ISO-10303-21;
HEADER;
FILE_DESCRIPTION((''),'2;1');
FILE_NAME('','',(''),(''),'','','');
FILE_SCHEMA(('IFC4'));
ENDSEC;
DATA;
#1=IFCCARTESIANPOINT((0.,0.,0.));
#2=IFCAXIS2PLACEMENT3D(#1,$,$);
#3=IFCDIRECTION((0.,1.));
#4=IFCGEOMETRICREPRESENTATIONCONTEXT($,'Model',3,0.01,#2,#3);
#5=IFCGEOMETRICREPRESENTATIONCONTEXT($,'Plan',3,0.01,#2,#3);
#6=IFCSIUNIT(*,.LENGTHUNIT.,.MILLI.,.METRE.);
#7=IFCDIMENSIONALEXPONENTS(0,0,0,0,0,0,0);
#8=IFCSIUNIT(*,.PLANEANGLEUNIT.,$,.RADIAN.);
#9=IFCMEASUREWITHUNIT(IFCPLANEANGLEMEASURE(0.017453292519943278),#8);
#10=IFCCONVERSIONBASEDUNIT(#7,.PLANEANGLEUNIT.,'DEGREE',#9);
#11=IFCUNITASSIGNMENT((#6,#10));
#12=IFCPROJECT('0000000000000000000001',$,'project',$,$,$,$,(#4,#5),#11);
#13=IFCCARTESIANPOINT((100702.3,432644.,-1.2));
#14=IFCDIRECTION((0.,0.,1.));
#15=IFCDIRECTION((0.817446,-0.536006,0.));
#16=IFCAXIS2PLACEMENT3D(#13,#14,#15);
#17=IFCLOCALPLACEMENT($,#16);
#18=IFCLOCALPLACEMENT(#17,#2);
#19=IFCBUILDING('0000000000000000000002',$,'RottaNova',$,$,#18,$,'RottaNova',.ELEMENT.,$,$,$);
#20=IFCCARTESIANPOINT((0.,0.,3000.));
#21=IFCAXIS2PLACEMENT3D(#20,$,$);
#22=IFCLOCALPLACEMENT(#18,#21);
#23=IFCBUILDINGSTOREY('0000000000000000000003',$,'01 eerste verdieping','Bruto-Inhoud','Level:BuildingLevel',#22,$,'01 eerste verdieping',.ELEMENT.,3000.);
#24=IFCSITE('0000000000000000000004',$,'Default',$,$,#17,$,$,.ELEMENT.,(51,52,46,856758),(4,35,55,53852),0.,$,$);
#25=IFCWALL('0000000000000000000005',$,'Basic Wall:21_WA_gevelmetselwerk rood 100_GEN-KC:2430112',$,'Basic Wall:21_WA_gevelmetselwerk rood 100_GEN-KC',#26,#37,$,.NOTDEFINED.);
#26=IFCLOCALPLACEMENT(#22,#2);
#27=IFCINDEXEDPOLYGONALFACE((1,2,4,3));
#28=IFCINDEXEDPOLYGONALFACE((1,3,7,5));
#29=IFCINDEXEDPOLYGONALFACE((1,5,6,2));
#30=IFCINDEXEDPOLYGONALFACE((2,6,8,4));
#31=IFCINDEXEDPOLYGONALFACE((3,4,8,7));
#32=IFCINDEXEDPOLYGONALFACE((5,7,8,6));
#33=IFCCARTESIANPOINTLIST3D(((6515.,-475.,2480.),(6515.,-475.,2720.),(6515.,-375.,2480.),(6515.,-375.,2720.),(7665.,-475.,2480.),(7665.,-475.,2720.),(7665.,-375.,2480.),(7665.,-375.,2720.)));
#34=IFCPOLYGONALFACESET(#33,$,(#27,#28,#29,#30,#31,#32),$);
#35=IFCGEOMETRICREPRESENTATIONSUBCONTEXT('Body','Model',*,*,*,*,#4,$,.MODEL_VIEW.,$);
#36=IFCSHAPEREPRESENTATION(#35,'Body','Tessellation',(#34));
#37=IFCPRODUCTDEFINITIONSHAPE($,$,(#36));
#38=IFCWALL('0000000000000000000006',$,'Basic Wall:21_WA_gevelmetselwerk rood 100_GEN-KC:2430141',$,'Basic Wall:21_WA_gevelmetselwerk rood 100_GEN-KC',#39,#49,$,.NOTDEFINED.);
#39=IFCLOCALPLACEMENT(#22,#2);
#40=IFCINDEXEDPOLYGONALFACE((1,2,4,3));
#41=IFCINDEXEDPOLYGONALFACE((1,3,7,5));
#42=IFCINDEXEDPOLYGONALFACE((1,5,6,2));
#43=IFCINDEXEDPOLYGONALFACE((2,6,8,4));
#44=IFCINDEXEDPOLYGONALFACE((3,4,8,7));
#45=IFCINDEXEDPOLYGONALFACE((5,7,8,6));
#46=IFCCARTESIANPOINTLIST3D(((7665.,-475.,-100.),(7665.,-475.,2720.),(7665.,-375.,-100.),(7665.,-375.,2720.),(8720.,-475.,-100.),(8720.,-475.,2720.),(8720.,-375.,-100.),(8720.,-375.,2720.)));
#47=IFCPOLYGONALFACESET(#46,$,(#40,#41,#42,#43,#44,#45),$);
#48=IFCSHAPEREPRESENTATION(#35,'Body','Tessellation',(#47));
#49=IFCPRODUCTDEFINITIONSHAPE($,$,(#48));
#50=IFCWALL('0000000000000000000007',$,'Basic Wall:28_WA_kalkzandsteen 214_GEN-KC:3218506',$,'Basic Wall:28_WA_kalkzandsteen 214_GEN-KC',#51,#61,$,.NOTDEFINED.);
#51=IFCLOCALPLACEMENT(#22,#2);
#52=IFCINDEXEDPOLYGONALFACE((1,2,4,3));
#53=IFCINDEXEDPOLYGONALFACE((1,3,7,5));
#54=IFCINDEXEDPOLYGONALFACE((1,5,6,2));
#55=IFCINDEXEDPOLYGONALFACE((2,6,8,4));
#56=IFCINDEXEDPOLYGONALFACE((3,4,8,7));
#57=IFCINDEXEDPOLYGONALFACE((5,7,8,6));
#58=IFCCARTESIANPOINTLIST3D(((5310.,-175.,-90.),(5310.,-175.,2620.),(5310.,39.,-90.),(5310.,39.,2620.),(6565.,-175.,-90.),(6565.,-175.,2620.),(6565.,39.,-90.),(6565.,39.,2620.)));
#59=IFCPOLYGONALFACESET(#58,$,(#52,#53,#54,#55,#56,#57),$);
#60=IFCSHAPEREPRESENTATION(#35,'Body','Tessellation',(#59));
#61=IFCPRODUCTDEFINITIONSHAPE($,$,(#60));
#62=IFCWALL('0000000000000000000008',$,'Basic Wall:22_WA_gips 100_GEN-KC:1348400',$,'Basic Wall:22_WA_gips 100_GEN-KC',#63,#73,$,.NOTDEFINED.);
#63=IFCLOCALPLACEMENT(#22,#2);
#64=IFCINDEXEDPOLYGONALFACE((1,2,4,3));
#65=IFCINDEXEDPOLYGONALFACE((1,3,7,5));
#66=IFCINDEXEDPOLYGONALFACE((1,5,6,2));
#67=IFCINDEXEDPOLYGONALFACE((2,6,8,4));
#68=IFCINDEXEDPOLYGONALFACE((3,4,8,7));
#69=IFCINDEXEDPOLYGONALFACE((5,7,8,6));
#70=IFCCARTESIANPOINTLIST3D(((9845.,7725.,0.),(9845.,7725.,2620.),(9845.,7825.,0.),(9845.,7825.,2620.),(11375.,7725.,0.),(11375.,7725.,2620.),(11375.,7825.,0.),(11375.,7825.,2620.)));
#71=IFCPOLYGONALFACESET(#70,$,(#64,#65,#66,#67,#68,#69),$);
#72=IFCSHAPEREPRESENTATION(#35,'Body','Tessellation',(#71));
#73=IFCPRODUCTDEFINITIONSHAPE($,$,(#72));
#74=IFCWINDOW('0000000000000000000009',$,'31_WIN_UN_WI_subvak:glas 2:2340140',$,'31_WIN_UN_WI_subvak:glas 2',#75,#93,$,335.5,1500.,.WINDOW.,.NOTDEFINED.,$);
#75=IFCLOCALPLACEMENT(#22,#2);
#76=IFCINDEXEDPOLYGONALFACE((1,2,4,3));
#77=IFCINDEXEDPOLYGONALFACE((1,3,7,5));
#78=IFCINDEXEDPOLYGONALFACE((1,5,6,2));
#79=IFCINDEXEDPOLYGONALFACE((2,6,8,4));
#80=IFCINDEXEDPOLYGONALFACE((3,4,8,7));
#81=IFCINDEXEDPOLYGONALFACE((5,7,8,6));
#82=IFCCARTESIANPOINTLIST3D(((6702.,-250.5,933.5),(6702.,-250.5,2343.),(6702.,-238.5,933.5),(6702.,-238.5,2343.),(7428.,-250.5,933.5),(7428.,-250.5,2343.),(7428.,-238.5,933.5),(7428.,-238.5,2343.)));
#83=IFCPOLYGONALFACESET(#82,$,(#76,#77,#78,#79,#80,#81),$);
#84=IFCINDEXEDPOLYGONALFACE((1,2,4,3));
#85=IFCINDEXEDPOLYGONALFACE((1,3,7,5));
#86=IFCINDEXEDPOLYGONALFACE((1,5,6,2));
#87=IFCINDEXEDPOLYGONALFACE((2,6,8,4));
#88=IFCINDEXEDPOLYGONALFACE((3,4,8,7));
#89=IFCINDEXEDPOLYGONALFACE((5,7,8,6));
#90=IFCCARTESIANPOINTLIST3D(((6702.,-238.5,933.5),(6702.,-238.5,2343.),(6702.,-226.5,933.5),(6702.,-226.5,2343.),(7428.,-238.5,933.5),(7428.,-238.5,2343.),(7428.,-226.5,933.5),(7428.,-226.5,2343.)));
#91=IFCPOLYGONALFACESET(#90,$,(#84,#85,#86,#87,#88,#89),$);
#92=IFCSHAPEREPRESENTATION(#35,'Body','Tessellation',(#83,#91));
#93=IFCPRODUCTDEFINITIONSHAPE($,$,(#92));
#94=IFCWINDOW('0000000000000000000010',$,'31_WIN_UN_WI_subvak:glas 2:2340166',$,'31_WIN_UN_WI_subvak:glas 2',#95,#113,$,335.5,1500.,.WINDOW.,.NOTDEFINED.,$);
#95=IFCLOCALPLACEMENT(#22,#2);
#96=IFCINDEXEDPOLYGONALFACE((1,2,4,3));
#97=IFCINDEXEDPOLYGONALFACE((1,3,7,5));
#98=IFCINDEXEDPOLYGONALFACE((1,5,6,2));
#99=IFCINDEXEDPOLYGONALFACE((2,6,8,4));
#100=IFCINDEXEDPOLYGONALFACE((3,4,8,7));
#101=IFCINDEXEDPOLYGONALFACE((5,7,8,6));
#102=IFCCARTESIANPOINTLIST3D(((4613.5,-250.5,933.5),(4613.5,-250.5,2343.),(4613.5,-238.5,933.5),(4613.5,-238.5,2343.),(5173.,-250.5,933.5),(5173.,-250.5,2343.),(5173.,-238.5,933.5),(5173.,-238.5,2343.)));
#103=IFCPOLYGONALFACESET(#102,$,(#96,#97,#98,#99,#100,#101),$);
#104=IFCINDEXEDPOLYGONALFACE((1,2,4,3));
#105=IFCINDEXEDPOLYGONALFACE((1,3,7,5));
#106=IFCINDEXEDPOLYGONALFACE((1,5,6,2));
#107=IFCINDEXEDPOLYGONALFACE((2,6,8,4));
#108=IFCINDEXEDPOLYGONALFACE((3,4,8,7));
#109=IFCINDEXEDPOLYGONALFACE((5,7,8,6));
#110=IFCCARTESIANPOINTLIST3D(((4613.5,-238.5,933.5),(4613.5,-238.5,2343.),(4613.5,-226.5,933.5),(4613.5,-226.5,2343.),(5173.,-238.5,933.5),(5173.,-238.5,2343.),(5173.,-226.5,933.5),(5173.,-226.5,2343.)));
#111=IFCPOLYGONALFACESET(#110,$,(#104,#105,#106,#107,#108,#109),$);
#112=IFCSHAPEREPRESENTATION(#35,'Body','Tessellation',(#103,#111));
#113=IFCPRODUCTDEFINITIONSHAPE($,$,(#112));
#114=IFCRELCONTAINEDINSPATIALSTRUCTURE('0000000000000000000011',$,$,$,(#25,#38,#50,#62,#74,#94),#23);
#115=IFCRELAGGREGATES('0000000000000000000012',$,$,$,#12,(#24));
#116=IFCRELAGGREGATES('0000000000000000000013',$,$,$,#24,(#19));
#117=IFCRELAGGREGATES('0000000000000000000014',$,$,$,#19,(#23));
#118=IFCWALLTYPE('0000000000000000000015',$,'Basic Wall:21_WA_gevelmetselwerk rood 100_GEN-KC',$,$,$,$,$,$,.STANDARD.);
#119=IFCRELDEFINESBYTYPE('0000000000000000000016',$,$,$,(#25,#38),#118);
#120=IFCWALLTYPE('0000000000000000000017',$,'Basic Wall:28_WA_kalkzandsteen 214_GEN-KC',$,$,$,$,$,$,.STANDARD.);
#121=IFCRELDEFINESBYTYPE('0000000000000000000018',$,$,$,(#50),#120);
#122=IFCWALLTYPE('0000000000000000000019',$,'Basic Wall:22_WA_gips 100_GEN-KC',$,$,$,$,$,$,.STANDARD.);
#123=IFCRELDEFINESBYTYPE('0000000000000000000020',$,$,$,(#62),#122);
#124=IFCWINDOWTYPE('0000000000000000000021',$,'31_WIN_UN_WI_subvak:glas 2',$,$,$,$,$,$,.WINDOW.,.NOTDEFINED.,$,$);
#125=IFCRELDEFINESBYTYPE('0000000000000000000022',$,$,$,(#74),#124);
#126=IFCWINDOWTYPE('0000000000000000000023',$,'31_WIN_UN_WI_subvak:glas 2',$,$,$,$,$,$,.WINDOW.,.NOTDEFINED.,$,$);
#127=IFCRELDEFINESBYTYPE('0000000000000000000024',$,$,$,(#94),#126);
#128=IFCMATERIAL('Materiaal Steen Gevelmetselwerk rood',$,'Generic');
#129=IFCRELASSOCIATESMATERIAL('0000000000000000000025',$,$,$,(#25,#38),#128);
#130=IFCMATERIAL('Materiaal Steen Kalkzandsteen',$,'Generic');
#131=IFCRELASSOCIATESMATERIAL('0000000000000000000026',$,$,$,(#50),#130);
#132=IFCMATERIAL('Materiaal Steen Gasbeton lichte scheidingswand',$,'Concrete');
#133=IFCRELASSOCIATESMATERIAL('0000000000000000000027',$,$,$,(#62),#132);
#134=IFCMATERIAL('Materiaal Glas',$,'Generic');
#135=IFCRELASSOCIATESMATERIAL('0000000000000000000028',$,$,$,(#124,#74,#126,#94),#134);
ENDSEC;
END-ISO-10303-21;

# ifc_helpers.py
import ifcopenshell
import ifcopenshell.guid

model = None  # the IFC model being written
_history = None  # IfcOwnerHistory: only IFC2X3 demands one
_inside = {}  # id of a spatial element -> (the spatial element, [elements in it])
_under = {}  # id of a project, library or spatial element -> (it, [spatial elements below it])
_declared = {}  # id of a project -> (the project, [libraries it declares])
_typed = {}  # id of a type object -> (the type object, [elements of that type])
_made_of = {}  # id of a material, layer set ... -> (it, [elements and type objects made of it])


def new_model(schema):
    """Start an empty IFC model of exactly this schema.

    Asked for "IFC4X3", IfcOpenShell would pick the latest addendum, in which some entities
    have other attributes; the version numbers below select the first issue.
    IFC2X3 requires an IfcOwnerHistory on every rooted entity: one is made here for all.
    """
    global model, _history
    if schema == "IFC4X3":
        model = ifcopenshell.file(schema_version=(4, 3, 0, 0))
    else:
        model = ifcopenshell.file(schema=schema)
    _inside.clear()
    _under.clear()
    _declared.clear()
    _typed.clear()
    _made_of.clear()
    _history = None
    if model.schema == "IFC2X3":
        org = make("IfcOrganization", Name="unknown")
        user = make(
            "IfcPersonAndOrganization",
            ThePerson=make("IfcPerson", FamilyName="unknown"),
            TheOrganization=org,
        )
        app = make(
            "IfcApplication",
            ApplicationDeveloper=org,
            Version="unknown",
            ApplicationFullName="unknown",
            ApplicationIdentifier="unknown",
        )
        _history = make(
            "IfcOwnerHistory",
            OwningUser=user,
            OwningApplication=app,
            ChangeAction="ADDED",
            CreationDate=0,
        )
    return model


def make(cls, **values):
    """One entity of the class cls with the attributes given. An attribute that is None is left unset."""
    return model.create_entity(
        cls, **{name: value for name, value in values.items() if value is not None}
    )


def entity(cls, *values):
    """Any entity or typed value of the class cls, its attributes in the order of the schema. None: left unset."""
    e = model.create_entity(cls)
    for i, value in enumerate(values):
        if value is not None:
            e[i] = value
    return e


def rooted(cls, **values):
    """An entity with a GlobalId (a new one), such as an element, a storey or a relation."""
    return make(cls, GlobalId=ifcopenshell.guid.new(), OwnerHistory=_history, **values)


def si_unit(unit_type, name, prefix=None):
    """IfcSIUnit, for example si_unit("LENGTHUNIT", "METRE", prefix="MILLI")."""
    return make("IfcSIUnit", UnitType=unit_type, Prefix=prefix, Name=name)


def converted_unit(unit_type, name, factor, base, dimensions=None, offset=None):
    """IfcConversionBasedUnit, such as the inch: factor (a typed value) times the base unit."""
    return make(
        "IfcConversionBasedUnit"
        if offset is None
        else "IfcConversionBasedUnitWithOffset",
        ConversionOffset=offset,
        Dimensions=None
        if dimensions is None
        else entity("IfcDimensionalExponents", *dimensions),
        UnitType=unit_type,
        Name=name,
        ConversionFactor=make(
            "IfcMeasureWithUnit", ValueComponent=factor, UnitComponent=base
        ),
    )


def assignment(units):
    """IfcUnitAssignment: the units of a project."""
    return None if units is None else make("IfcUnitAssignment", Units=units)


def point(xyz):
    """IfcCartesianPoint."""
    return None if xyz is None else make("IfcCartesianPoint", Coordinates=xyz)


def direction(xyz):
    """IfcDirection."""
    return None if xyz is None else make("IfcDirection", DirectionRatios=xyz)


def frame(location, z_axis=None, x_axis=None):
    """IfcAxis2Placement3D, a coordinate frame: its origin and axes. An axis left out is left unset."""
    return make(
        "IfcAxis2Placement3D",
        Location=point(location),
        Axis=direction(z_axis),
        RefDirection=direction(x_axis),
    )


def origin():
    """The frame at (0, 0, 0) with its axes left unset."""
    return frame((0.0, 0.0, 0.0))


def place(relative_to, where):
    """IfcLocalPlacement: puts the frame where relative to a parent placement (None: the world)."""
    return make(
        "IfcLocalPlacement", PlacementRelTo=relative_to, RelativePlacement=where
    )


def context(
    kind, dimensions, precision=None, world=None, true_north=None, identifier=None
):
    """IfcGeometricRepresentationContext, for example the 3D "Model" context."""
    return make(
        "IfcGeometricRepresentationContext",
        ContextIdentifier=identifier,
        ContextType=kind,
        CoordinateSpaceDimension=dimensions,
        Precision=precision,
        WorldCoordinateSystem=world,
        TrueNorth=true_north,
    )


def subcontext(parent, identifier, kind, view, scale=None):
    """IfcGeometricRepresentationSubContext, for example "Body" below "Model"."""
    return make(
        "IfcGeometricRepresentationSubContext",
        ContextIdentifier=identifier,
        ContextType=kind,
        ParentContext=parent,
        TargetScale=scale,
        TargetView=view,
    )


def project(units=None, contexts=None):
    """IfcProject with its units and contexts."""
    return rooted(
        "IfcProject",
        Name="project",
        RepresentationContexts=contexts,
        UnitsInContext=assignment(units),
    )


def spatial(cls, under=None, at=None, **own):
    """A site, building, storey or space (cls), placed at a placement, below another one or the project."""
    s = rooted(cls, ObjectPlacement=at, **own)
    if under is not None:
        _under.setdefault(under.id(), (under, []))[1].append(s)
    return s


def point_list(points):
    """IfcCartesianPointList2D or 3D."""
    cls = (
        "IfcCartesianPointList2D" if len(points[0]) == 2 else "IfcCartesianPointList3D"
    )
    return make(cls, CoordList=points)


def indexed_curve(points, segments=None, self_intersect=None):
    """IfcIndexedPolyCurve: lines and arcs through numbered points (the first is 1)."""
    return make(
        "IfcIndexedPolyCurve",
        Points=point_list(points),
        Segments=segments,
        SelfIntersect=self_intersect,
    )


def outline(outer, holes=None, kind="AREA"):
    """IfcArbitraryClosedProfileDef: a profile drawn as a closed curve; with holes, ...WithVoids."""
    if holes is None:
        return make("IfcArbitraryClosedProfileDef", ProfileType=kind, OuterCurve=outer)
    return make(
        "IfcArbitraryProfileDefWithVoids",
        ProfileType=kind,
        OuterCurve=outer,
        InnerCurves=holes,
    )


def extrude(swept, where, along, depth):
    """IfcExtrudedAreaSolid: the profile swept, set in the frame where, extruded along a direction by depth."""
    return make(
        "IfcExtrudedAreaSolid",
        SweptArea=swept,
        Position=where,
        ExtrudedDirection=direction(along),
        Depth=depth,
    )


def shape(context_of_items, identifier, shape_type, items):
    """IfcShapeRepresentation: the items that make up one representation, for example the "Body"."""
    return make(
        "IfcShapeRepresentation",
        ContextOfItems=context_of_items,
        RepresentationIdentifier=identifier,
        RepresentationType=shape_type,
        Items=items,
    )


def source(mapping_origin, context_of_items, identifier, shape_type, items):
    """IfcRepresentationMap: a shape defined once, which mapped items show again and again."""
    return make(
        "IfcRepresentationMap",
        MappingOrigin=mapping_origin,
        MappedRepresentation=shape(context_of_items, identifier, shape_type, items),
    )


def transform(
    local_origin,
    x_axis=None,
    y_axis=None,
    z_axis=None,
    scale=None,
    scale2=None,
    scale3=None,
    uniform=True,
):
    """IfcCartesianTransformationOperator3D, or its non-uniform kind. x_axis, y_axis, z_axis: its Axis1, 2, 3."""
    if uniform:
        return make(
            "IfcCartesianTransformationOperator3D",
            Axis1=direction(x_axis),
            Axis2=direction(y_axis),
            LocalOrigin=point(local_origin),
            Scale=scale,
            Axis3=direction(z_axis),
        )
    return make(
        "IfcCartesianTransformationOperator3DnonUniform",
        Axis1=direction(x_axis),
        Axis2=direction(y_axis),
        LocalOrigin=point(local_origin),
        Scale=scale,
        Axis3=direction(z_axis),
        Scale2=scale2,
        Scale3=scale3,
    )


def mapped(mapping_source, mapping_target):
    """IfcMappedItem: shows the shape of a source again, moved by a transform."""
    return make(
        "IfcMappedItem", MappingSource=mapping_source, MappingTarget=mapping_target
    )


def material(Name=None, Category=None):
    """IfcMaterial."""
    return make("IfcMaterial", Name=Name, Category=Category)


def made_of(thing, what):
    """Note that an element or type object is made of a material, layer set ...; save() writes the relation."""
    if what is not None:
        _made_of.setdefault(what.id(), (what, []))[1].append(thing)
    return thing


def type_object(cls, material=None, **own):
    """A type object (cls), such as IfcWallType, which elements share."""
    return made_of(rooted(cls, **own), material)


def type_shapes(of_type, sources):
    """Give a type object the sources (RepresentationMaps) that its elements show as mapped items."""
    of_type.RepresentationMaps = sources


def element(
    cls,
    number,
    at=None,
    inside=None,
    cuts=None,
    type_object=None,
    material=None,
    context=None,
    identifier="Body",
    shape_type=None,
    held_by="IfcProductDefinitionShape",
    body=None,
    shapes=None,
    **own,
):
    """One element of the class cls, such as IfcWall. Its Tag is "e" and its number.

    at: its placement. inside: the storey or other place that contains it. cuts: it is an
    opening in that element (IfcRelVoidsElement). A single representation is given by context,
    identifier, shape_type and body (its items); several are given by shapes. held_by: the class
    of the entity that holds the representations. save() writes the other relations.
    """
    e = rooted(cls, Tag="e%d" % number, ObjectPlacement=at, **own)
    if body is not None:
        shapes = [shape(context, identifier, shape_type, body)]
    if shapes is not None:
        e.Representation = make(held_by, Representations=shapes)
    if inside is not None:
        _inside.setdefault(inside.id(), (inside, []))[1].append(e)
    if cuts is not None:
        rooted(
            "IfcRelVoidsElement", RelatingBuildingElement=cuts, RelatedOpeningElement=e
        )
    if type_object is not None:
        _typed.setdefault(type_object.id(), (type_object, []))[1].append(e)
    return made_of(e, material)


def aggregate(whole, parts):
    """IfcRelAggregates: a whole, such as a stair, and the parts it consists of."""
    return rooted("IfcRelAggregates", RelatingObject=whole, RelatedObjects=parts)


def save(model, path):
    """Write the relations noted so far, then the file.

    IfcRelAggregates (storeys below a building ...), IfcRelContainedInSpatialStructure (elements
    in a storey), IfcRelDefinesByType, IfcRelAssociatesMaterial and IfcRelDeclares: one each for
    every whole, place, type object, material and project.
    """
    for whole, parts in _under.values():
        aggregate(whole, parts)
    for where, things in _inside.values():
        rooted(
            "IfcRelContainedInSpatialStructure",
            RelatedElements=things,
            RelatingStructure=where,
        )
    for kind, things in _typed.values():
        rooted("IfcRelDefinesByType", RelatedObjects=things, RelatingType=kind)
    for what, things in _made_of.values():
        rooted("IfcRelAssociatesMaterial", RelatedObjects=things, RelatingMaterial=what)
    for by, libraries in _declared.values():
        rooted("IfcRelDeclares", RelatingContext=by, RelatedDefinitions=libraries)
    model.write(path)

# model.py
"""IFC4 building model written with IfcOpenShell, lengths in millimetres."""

from ifc_helpers import new_model, entity, si_unit, converted_unit, direction, frame, origin, place, context, subcontext, project, spatial, indexed_curve, outline, extrude, source, transform, mapped, material, type_object, type_shapes, element, save


model = new_model("IFC4")

# Units and contexts
model_context = context("Model", 3, precision=0.01, world=origin(), true_north=direction((0.0, 1.0)))
plan_context = context("Plan", 3, precision=0.01, world=origin(), true_north=direction((0.0, 1.0)))
body_context = subcontext(model_context, "Body", "Model", "MODEL_VIEW")
ifc_project = project(units=[si_unit("LENGTHUNIT", "METRE", prefix="MILLI"), converted_unit("PLANEANGLEUNIT", "DEGREE", entity("IfcPlaneAngleMeasure", 0.017453292519943278), si_unit("PLANEANGLEUNIT", "RADIAN"), dimensions=[0, 0, 0, 0, 0, 0, 0])], contexts=[model_context, plan_context])

# Site, building, storey
site_placement = place(None, frame((100702.3, 432644.0, -1.2), z_axis=(0.0, 0.0, 1.0), x_axis=(0.817446, -0.536006, 0.0)))
site = spatial("IfcSite", under=ifc_project, at=site_placement, Name="Default", CompositionType="ELEMENT", RefLatitude=(51, 52, 46, 856758), RefLongitude=(4, 35, 55, 53852), RefElevation=0.0)
building_placement = place(site_placement, origin())
building = spatial("IfcBuilding", under=site, at=building_placement, Name="RottaNova", LongName="RottaNova", CompositionType="ELEMENT")
storey_placement = place(building_placement, frame((0.0, 0.0, 3000.0)))
storey = spatial("IfcBuildingStorey", under=building, at=storey_placement, Name="01 eerste verdieping", Description="Bruto-Inhoud", ObjectType="Level:BuildingLevel", LongName="01 eerste verdieping", CompositionType="ELEMENT", Elevation=3000.0)

# Shared definitions
ifc_material_1 = material(Name="Materiaal Glas", Category="Generic")

# Walls
ifc_material_2 = material(Name="Materiaal Steen Gevelmetselwerk rood", Category="Generic")
wall_type_1 = type_object("IfcWallType", Name="Basic Wall:21_WA_gevelmetselwerk rood 100_GEN-KC", PredefinedType="STANDARD")
wall_1_placement = place(storey_placement, frame((6515.0, -425.0, 2480.0)))
element("IfcWall", 1, at=wall_1_placement, inside=storey, type_object=wall_type_1, material=ifc_material_2, Name="Basic Wall:21_WA_gevelmetselwerk rood 100_GEN-KC:2430112", ObjectType="Basic Wall:21_WA_gevelmetselwerk rood 100_GEN-KC", PredefinedType="NOTDEFINED", context=body_context, shape_type="SweptSolid", body=[
    extrude(outline(indexed_curve([(1150.0, 50.0), (0.0, 50.0), (0.0, -50.0), (1150.0, -50.0), (1150.0, 50.0)], self_intersect=False)), origin(), (0.0, 0.0, 1.0), 240.0),
])
wall_2_placement = place(storey_placement, frame((7665.0, -425.0, -100.0)))
element("IfcWall", 2, at=wall_2_placement, inside=storey, type_object=wall_type_1, material=ifc_material_2, Name="Basic Wall:21_WA_gevelmetselwerk rood 100_GEN-KC:2430141", ObjectType="Basic Wall:21_WA_gevelmetselwerk rood 100_GEN-KC", PredefinedType="NOTDEFINED", context=body_context, shape_type="SweptSolid", body=[
    extrude(outline(indexed_curve([(1055.0, 50.0), (0.0, 50.0), (0.0, -50.0), (1055.0, -50.0), (1055.0, 50.0)], self_intersect=False)), origin(), (0.0, 0.0, 1.0), 2820.0),
])
ifc_material_3 = material(Name="Materiaal Steen Kalkzandsteen", Category="Generic")
wall_type_2 = type_object("IfcWallType", Name="Basic Wall:28_WA_kalkzandsteen 214_GEN-KC", PredefinedType="STANDARD")
wall_3_placement = place(storey_placement, frame((6565.0, -68.0, -90.0), z_axis=(0.0, 0.0, 1.0), x_axis=(-1.0, 0.0, 0.0)))
element("IfcWall", 3, at=wall_3_placement, inside=storey, type_object=wall_type_2, material=ifc_material_3, Name="Basic Wall:28_WA_kalkzandsteen 214_GEN-KC:3218506", ObjectType="Basic Wall:28_WA_kalkzandsteen 214_GEN-KC", PredefinedType="NOTDEFINED", context=body_context, shape_type="SweptSolid", body=[
    extrude(outline(indexed_curve([(1255.0, 107.0), (0.0, 107.0), (0.0, -107.0), (1255.0, -107.0), (1255.0, 107.0)], self_intersect=False)), origin(), (0.0, 0.0, 1.0), 2710.0),
])
ifc_material_4 = material(Name="Materiaal Steen Gasbeton lichte scheidingswand", Category="Concrete")
wall_type_3 = type_object("IfcWallType", Name="Basic Wall:22_WA_gips 100_GEN-KC", PredefinedType="STANDARD")
wall_4_placement = place(storey_placement, frame((9845.0, 7775.0, 0.0)))
element("IfcWall", 4, at=wall_4_placement, inside=storey, type_object=wall_type_3, material=ifc_material_4, Name="Basic Wall:22_WA_gips 100_GEN-KC:1348400", ObjectType="Basic Wall:22_WA_gips 100_GEN-KC", PredefinedType="NOTDEFINED", context=body_context, shape_type="SweptSolid", body=[
    extrude(outline(indexed_curve([(1530.0, 50.0), (0.0, 50.0), (0.0, -50.0), (1530.0, -50.0), (1530.0, 50.0)], self_intersect=False)), origin(), (0.0, 0.0, 1.0), 2620.0),
])

# Windows
window_type_1 = type_object("IfcWindowType", Name="31_WIN_UN_WI_subvak:glas 2", PartitioningType="NOTDEFINED", PredefinedType="WINDOW", material=ifc_material_1)
shared_shape_1 = source(origin(), body_context, "Body", "SweptSolid", [
    extrude(outline(indexed_curve([(-363.0, -6.0), (363.0, -6.0), (363.0, 6.0), (-363.0, 6.0), (-363.0, -6.0)], self_intersect=False)), frame((0.0, -6.0, 0.0)), (0.0, 0.0, 1.0), 1409.5),
    extrude(outline(indexed_curve([(-363.0, -6.0), (363.0, -6.0), (363.0, 6.0), (-363.0, 6.0), (-363.0, -6.0)], self_intersect=False)), frame((0.0, 6.0, 0.0)), (0.0, 0.0, 1.0), 1409.5),
])
type_shapes(window_type_1, [shared_shape_1])
window_1_placement = place(storey_placement, frame((7065.0, -238.5, 933.5)))
element("IfcWindow", 5, at=window_1_placement, inside=storey, type_object=window_type_1, material=ifc_material_1, Name="31_WIN_UN_WI_subvak:glas 2:2340140", ObjectType="31_WIN_UN_WI_subvak:glas 2", OverallHeight=335.5, OverallWidth=1500.0, PartitioningType="NOTDEFINED", PredefinedType="WINDOW", context=body_context, shape_type="MappedRepresentation", body=[
    mapped(shared_shape_1, transform((0.0, 0.0, 0.0), scale=1.0)),
])
window_type_2 = type_object("IfcWindowType", Name="31_WIN_UN_WI_subvak:glas 2", PartitioningType="NOTDEFINED", PredefinedType="WINDOW", material=ifc_material_1)
shared_shape_2 = source(origin(), body_context, "Body", "SweptSolid", [
    extrude(outline(indexed_curve([(-6.0, -279.8), (6.0, -279.8), (6.0, 279.8), (-6.0, 279.8), (-6.0, -279.8)], self_intersect=False)), frame((0.0, 6.0, 0.0), z_axis=(0.0, 0.0, 1.0), x_axis=(0.0, -1.0, 0.0)), (0.0, 0.0, 1.0), 1409.5),
    extrude(outline(indexed_curve([(-6.0, -279.8), (6.0, -279.8), (6.0, 279.8), (-6.0, 279.8), (-6.0, -279.8)], self_intersect=False)), frame((0.0, -6.0, 0.0), z_axis=(0.0, 0.0, 1.0), x_axis=(0.0, -1.0, 0.0)), (0.0, 0.0, 1.0), 1409.5),
])
type_shapes(window_type_2, [shared_shape_2])
window_2_placement = place(storey_placement, frame((4893.2, -238.5, 933.5), z_axis=(0.0, 0.0, 1.0), x_axis=(-1.0, 0.0, 0.0)))
element("IfcWindow", 6, at=window_2_placement, inside=storey, type_object=window_type_2, material=ifc_material_1, Name="31_WIN_UN_WI_subvak:glas 2:2340166", ObjectType="31_WIN_UN_WI_subvak:glas 2", OverallHeight=335.5, OverallWidth=1500.0, PartitioningType="NOTDEFINED", PredefinedType="WINDOW", context=body_context, shape_type="MappedRepresentation", body=[
    mapped(shared_shape_2, transform((0.0, 0.0, 0.0), scale=1.0)),
])

save(model, "model.ifc")
